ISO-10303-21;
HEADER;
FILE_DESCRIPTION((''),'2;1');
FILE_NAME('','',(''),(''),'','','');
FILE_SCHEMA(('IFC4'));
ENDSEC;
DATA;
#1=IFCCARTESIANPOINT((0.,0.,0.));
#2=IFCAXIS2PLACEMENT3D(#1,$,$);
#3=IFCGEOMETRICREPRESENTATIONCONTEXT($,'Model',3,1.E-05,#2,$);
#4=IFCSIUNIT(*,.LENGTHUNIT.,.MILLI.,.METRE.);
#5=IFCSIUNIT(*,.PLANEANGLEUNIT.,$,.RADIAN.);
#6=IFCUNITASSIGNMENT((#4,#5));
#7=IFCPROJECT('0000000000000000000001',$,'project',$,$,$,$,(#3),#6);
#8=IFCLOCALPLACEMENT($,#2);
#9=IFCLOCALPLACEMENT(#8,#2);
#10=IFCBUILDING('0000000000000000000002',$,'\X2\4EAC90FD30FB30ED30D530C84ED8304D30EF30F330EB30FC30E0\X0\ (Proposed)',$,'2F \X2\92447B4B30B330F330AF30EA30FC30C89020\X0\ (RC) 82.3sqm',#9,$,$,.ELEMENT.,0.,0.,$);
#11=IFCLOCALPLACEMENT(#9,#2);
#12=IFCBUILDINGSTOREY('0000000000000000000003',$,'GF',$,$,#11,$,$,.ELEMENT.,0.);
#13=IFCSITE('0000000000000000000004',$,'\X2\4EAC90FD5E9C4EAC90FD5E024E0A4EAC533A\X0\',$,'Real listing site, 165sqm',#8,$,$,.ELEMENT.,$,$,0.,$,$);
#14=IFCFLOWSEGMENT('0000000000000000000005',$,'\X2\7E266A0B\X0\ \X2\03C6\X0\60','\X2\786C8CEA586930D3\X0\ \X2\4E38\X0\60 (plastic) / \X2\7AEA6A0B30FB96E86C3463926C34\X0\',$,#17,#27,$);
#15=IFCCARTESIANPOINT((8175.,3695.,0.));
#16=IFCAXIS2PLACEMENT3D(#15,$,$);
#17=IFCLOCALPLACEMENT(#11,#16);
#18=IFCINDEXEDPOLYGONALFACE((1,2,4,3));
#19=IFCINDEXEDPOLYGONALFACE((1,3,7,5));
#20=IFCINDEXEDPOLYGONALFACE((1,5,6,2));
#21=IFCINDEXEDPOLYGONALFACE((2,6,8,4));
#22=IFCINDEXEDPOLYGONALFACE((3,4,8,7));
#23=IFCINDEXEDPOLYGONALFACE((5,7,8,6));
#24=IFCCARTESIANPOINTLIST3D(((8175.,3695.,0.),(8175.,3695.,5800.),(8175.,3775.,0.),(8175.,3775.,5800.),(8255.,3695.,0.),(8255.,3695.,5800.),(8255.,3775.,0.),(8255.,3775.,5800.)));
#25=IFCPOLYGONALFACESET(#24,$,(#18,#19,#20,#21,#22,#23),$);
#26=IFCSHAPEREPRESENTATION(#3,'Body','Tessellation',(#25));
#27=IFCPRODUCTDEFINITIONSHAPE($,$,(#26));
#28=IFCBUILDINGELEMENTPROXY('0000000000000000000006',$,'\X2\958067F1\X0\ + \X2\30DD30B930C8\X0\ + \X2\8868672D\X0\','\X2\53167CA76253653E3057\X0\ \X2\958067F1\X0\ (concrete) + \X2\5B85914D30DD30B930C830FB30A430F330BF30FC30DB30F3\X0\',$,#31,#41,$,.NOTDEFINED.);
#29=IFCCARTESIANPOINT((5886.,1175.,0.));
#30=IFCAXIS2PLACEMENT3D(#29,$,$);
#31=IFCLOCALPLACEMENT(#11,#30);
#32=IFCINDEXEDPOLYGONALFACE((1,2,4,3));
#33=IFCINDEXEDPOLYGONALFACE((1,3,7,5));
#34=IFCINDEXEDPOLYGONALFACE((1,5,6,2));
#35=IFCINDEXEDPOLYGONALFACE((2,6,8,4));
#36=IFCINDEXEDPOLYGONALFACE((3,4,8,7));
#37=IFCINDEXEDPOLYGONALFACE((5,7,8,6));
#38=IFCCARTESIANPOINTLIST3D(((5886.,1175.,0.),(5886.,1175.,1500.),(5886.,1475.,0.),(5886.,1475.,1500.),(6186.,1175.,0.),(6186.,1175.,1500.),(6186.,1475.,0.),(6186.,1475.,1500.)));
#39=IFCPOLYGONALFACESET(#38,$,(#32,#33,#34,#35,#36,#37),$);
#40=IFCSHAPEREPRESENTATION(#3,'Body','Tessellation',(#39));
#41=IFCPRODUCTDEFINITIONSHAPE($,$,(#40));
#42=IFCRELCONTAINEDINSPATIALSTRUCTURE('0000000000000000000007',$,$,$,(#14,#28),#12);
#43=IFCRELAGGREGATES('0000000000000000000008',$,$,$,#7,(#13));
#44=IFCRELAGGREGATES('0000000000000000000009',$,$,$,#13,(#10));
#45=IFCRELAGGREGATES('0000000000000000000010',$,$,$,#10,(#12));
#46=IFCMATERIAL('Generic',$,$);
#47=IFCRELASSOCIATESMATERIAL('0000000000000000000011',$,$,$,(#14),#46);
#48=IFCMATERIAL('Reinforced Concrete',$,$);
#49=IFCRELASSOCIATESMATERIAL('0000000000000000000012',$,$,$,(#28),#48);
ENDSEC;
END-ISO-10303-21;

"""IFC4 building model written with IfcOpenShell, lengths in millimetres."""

from ifc_helpers import new_model, si_unit, frame, frame_2d, origin, place, context, project, spatial, rectangle, extrude, material, element, save


model = new_model("IFC4")

# Units and contexts
model_context = context("Model", 3, precision=1e-05, world=origin())
ifc_project = project(units=[si_unit("LENGTHUNIT", "METRE", prefix="MILLI"), si_unit("PLANEANGLEUNIT", "RADIAN")], contexts=[model_context])

# Site, building, storey
site_placement = place(None, origin())
site = spatial("IfcSite", under=ifc_project, at=site_placement, Name="京都府京都市上京区", ObjectType="Real listing site, 165sqm", CompositionType="ELEMENT", RefElevation=0.0)
building_placement = place(site_placement, origin())
building = spatial("IfcBuilding", under=site, at=building_placement, Name="京都・ロフト付きワンルーム (Proposed)", ObjectType="2F 鉄筋コンクリート造 (RC) 82.3sqm", CompositionType="ELEMENT", ElevationOfRefHeight=0.0, ElevationOfTerrain=0.0)
storey_placement = place(building_placement, origin())
storey = spatial("IfcBuildingStorey", under=building, at=storey_placement, Name="GF", CompositionType="ELEMENT", Elevation=0.0)

# Shared definitions
ifc_material_1 = material(Name="Reinforced Concrete")

# Flow segment
ifc_material_2 = material(Name="Generic")
flow_segment_1_placement = place(storey_placement, frame((8175.0, 3695.0, 0.0)))
element("IfcFlowSegment", 1, at=flow_segment_1_placement, inside=storey, material=ifc_material_2, Name="縦樋 φ60", Description="硬質塩ビ 丸60 (plastic) / 竪樋・雨水排水", context=model_context, shape_type="SweptSolid", body=[
    extrude(rectangle(XDim=80.0, YDim=80.0, at=frame_2d((40.0, 40.0))), frame((8175.0, 3695.0, 0.0)), (0.0, 0.0, 1.0), 5800.0),
])

# Building element proxy
proxy_placement = place(storey_placement, frame((5886.0, 1175.0, 0.0)))
element("IfcBuildingElementProxy", 2, at=proxy_placement, inside=storey, material=ifc_material_1, Name="門柱 + ポスト + 表札", Description="化粧打放し 門柱 (concrete) + 宅配ポスト・インターホン", PredefinedType="NOTDEFINED", context=model_context, shape_type="SweptSolid", body=[
    extrude(rectangle(XDim=300.0, YDim=300.0, at=frame_2d((150.0, 150.0))), frame((5886.0, 1175.0, 0.0)), (0.0, 0.0, 1.0), 1500.0),
])

save(model, "model.ifc")
